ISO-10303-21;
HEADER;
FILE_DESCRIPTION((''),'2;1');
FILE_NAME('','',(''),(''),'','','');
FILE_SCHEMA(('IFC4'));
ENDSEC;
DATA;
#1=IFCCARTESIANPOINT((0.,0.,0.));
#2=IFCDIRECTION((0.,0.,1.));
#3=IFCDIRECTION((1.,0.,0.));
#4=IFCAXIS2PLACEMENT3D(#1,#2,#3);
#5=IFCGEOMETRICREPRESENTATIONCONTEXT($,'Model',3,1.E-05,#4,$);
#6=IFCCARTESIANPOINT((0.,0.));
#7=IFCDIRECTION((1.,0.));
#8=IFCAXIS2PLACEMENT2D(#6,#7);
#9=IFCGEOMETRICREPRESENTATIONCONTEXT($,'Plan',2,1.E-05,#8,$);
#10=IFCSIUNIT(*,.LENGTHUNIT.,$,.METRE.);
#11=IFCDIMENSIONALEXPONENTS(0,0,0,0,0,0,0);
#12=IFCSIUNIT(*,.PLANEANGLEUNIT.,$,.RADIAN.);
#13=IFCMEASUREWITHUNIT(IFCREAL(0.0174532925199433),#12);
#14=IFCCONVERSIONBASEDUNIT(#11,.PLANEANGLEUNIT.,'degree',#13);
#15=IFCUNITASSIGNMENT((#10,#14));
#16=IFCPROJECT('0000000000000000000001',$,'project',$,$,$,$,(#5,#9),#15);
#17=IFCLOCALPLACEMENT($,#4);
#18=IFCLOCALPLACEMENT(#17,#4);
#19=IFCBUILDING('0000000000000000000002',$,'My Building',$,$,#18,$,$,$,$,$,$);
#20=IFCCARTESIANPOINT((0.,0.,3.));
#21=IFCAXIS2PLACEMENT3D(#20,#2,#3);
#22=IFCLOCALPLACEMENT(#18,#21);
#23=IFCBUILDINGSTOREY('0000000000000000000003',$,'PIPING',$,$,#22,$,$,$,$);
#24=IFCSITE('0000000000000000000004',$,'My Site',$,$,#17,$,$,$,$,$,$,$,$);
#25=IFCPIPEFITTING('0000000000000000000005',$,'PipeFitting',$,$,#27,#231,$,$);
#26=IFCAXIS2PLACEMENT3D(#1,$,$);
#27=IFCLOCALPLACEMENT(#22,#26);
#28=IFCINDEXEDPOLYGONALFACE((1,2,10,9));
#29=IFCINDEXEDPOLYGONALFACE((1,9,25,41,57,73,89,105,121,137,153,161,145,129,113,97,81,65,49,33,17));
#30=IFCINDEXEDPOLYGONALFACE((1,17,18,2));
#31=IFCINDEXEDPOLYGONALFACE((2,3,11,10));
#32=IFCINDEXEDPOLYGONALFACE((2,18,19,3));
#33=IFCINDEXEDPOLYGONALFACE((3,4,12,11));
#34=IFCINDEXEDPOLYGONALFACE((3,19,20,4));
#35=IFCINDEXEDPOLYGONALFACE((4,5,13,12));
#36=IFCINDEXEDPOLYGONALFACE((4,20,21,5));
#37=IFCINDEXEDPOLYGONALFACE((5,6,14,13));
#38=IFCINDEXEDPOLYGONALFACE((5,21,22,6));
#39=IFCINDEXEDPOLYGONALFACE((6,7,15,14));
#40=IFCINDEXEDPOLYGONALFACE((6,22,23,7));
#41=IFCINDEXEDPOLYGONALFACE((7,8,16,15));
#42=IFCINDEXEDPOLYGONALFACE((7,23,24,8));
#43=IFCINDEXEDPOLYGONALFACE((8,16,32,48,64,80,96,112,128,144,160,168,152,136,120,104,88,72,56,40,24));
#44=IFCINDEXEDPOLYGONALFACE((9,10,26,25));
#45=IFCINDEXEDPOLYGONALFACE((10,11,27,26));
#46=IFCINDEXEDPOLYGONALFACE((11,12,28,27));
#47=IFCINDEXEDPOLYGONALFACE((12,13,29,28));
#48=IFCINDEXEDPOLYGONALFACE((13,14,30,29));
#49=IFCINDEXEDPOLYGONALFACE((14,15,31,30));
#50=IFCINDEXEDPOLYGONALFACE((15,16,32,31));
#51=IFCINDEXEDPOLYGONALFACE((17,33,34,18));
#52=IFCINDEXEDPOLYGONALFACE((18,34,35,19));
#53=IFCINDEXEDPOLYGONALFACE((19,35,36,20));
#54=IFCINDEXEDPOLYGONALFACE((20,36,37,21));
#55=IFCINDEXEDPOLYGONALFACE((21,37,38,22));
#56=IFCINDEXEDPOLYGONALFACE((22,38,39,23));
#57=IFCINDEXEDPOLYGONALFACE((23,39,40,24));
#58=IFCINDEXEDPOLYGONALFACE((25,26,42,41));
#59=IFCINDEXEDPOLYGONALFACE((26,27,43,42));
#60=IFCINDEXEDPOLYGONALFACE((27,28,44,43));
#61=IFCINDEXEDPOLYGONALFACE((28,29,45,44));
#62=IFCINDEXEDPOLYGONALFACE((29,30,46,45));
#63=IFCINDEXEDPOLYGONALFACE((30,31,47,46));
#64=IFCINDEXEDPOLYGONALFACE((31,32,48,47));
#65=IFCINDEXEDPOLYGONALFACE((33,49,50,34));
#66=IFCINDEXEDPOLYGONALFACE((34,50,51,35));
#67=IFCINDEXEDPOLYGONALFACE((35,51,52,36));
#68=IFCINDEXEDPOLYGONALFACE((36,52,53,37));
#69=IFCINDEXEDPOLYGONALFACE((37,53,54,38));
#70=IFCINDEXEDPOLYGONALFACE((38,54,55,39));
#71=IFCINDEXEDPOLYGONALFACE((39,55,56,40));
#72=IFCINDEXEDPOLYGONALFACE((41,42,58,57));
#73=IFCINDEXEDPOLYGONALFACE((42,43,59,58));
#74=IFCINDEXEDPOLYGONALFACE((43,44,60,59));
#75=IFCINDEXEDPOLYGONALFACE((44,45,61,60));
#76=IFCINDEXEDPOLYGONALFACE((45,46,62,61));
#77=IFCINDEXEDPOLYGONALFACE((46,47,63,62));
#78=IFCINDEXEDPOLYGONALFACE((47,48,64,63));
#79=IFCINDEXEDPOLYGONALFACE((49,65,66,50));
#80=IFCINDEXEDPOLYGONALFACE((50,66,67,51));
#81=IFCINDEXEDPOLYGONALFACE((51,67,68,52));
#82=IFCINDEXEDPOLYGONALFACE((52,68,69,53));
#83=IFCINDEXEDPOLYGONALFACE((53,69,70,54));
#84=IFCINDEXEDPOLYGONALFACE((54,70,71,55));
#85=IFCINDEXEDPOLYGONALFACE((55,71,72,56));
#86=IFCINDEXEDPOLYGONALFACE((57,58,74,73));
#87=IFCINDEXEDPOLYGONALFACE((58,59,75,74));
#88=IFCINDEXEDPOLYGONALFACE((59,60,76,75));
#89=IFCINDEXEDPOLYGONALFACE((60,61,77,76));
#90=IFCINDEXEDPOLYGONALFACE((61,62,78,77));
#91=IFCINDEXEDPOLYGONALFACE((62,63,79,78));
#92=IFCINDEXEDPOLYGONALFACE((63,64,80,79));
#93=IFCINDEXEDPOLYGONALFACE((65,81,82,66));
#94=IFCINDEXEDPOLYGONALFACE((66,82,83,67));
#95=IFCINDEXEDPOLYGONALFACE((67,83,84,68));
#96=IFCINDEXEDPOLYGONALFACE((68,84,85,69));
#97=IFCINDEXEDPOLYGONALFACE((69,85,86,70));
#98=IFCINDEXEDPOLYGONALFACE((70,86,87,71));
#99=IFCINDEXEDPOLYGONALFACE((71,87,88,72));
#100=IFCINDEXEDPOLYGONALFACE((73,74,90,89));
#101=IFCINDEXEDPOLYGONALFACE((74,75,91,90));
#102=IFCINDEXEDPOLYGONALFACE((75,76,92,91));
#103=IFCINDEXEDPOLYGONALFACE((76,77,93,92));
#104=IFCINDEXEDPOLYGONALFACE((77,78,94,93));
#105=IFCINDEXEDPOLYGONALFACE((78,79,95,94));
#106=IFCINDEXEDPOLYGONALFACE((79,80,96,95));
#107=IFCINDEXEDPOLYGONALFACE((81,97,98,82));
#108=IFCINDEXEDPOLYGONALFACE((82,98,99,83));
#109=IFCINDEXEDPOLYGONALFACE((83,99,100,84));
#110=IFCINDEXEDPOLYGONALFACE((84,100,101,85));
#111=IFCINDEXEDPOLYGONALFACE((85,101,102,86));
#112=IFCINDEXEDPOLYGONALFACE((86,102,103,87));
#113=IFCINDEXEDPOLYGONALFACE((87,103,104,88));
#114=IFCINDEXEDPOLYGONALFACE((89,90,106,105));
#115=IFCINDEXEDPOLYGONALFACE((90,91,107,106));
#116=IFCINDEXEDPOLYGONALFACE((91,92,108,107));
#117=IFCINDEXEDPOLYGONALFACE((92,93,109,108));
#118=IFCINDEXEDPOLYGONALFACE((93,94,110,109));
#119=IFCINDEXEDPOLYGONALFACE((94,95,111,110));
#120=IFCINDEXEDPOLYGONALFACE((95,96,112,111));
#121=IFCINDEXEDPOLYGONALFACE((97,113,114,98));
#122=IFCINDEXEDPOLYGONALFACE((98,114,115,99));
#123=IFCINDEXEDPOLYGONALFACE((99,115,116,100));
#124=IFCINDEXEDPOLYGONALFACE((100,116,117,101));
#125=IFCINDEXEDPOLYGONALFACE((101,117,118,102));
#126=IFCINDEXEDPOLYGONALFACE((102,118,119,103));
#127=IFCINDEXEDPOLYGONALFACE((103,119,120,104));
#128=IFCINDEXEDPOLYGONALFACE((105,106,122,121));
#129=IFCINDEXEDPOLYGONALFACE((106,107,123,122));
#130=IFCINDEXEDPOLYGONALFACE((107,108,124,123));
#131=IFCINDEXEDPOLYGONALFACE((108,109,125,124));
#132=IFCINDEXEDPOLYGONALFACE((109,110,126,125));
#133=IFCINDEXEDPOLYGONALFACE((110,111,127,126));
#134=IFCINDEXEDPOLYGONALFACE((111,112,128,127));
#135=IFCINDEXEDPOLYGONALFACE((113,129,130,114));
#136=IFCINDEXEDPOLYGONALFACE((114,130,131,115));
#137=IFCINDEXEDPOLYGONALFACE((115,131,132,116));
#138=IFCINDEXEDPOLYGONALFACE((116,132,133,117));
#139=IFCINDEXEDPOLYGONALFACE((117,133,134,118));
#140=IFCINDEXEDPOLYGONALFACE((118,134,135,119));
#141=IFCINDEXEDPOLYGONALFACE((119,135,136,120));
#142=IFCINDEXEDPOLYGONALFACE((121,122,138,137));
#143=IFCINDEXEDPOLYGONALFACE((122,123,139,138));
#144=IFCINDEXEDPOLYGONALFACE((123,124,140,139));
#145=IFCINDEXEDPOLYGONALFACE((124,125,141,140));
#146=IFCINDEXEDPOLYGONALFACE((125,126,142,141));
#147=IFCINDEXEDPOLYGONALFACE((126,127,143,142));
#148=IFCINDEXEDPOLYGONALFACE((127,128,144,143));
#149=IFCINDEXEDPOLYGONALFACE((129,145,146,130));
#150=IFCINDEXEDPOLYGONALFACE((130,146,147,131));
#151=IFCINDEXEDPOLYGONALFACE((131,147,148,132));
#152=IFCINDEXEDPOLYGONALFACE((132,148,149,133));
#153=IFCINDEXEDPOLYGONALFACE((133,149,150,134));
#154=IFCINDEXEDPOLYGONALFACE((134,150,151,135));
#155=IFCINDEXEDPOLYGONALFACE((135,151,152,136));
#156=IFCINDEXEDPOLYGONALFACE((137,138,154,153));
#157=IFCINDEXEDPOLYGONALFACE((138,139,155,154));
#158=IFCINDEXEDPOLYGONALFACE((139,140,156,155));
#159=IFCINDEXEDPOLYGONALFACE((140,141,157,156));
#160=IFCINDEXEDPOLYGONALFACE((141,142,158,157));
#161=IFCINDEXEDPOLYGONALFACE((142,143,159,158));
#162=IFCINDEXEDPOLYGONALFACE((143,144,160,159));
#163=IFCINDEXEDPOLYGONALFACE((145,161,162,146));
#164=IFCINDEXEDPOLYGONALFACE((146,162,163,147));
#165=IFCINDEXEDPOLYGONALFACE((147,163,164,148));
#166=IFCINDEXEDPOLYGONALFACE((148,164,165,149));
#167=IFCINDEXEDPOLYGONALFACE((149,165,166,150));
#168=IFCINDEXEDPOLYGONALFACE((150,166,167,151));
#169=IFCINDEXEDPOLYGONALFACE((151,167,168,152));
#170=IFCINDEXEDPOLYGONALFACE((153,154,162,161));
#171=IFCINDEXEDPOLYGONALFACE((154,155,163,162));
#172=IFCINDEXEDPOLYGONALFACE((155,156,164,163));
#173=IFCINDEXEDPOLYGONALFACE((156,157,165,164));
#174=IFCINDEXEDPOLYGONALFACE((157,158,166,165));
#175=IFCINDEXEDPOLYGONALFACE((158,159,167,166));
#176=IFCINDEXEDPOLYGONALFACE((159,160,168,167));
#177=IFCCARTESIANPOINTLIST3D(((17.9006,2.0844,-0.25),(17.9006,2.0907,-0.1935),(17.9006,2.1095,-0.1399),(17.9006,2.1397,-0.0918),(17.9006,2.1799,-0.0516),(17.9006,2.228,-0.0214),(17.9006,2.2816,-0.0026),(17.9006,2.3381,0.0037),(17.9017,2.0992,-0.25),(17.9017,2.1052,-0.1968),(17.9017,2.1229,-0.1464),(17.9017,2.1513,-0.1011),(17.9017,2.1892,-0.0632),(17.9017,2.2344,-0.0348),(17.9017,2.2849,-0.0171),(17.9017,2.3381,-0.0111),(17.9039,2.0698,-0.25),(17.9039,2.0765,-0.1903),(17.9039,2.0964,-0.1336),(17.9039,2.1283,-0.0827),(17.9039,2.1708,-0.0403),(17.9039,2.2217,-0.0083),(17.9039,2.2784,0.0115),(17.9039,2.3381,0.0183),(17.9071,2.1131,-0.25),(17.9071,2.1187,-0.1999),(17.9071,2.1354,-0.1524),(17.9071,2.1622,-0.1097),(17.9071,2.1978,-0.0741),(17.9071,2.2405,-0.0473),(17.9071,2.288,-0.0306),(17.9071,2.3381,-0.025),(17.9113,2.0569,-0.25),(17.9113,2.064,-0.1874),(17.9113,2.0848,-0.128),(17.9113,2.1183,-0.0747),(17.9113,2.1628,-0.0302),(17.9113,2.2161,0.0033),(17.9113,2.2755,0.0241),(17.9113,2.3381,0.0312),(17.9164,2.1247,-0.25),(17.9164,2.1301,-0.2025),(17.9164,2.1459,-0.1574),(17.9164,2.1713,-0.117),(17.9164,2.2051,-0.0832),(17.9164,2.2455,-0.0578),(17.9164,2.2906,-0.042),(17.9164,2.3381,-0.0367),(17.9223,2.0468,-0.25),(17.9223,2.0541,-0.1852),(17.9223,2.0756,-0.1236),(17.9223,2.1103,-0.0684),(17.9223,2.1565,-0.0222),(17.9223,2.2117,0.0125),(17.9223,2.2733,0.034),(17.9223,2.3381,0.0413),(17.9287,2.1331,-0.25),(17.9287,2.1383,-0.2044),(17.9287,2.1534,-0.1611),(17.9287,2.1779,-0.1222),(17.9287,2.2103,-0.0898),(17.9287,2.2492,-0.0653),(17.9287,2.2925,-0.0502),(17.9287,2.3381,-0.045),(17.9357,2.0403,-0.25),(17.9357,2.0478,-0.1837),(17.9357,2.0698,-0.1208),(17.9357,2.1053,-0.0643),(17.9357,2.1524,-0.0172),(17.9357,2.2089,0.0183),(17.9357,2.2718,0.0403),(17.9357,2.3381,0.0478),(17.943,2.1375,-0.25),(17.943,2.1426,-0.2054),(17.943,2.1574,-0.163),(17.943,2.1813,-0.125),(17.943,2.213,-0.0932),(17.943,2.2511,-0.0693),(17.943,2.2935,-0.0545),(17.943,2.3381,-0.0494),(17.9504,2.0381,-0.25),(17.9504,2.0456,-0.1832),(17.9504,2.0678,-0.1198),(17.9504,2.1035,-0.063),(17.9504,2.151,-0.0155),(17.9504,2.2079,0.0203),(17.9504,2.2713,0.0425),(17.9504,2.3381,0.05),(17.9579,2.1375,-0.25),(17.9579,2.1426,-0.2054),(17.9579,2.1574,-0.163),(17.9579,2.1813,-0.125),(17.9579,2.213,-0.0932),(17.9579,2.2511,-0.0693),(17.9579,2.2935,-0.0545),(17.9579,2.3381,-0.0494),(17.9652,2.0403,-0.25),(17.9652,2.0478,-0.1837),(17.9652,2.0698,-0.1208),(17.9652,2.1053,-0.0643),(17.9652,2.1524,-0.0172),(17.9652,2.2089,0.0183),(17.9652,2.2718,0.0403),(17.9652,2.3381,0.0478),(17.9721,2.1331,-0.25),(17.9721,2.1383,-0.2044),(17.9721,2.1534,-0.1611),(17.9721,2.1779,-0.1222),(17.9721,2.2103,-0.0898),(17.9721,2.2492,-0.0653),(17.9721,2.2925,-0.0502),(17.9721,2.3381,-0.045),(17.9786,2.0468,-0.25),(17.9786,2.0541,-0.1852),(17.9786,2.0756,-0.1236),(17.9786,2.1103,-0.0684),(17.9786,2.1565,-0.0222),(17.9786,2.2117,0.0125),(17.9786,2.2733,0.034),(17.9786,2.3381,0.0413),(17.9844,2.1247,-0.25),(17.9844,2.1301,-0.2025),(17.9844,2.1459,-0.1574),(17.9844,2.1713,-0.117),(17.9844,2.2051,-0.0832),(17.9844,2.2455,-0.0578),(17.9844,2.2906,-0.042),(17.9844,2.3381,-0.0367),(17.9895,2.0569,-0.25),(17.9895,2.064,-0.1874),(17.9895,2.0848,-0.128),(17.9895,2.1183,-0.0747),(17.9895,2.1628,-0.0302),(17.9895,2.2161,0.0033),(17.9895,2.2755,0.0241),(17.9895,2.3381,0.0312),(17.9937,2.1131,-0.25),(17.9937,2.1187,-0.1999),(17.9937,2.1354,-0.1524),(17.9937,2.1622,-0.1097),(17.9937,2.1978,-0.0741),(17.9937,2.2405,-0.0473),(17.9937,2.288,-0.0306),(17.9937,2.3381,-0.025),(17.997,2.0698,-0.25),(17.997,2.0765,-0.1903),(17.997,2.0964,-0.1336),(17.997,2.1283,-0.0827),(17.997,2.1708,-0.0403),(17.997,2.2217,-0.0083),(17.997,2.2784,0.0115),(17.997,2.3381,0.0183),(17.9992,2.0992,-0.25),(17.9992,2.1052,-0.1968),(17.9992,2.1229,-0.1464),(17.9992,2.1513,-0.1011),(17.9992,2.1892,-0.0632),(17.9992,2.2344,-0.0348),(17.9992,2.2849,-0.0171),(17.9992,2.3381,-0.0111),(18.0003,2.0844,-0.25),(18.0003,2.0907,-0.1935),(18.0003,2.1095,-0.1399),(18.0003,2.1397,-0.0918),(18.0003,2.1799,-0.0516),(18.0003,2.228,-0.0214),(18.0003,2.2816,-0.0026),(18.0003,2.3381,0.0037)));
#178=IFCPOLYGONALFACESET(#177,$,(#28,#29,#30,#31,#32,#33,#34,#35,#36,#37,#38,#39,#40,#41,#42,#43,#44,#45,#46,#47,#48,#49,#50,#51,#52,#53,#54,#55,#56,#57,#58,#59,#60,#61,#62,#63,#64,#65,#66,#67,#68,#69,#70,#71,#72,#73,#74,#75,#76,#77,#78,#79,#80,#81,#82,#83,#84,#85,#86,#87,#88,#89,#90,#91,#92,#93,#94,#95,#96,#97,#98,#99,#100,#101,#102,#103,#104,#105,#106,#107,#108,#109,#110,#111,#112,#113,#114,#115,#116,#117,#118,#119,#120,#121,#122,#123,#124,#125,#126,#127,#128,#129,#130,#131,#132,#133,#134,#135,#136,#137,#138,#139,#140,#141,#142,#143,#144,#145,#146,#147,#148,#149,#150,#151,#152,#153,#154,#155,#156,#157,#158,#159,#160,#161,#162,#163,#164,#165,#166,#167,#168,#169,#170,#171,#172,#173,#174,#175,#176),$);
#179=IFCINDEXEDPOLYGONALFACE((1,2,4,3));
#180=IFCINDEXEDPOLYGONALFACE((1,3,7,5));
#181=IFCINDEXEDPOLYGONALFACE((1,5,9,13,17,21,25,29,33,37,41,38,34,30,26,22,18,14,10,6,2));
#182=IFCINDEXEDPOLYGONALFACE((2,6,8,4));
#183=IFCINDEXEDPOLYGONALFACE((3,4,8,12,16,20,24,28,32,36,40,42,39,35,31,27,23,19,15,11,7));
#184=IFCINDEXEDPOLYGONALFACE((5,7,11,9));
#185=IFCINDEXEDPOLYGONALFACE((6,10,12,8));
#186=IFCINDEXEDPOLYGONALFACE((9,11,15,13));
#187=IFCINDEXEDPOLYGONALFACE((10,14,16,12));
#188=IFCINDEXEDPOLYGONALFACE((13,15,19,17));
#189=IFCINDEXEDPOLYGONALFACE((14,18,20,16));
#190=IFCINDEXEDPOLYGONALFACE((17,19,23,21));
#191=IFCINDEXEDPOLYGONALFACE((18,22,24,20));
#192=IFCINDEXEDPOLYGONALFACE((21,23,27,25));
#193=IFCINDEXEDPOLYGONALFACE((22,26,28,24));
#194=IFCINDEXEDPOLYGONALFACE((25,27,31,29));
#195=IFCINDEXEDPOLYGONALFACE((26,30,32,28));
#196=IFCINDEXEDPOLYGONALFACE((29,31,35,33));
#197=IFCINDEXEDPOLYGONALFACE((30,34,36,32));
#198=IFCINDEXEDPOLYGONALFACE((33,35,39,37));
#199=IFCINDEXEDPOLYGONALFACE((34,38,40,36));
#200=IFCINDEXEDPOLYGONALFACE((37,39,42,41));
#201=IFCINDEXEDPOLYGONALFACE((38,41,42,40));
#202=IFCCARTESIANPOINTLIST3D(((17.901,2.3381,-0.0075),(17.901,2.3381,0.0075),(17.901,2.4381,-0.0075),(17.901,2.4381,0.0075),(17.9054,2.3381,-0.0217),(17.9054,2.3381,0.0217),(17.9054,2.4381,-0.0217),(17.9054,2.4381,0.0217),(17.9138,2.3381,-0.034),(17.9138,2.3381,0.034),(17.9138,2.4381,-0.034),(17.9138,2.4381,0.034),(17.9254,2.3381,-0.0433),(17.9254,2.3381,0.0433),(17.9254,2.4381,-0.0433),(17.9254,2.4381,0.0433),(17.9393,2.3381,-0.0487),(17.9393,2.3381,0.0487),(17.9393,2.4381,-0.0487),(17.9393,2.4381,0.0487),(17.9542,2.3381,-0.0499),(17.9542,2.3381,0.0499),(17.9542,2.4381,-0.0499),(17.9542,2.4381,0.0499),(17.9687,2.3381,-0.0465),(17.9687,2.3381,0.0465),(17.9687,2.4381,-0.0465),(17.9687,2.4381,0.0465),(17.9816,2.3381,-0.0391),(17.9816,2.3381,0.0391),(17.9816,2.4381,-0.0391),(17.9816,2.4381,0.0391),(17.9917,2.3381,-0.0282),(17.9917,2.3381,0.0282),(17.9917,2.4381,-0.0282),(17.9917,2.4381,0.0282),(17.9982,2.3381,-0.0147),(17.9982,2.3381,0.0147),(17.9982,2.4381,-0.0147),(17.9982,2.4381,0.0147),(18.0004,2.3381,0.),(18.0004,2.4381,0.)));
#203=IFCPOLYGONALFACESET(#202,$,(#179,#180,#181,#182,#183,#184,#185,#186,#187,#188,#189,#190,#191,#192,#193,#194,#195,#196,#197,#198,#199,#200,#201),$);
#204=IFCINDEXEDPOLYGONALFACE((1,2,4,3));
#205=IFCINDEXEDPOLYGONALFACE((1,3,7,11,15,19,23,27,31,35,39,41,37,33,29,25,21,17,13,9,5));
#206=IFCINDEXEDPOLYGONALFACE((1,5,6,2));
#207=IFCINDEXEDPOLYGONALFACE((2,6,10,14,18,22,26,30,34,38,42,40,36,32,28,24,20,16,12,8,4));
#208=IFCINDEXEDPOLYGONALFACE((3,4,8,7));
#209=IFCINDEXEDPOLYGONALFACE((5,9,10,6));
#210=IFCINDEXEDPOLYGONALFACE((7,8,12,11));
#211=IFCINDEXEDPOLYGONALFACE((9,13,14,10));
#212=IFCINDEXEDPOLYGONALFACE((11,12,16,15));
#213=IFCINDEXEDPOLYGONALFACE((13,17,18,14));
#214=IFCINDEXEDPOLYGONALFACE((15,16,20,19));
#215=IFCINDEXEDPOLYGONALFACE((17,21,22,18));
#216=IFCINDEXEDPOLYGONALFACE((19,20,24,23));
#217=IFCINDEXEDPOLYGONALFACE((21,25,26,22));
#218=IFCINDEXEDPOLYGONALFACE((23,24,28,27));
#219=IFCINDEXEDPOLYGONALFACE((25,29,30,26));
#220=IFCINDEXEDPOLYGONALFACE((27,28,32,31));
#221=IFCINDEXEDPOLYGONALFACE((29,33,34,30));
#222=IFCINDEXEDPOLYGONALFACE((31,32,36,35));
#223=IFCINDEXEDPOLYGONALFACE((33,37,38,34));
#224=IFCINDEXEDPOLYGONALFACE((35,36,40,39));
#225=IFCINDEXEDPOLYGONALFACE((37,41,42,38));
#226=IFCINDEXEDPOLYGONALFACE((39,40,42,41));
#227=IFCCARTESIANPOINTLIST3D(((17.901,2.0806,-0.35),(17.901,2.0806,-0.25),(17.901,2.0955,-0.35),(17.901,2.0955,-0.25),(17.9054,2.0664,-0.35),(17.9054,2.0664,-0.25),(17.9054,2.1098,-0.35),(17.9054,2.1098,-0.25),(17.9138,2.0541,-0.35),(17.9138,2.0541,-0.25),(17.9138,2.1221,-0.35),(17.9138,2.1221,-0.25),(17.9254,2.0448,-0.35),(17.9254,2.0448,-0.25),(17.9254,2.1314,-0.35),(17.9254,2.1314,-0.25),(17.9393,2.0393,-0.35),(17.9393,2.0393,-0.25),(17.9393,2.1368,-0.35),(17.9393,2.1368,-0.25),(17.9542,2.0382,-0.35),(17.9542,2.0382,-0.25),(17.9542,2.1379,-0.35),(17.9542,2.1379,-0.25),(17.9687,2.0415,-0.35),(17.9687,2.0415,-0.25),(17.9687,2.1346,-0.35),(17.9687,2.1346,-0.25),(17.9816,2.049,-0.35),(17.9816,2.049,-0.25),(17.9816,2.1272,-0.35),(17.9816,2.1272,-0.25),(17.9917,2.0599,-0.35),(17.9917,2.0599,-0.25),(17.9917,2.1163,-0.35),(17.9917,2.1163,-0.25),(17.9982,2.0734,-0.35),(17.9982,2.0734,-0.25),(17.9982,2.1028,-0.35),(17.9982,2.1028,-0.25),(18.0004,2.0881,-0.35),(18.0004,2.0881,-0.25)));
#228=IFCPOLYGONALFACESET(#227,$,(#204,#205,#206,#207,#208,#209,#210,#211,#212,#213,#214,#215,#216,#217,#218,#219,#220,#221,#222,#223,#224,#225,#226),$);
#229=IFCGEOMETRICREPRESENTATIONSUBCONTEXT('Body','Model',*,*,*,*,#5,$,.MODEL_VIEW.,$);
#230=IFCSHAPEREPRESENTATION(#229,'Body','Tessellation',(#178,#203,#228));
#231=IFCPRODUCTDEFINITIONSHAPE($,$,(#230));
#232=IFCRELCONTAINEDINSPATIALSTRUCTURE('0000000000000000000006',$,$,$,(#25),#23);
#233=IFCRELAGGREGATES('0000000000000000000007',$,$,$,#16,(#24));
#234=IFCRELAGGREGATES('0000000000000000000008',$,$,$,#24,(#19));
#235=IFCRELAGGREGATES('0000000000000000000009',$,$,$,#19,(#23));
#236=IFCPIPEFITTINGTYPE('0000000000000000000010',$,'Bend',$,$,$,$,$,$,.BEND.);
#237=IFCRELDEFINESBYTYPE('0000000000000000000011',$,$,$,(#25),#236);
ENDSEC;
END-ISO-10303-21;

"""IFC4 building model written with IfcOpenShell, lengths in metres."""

from ifc_helpers import new_model, entity, si_unit, converted_unit, frame, origin_with_axes, origin_2d_with_axis, place, context, subcontext, project, spatial, circle, extrude, source, transform, mapped, type_object, type_shapes, element, save


model = new_model("IFC4")

# Units and contexts
model_context = context("Model", 3, precision=1e-05, world=origin_with_axes())
plan_context = context("Plan", 2, precision=1e-05, world=origin_2d_with_axis())
body_context = subcontext(model_context, "Body", "Model", "MODEL_VIEW")
ifc_project = project(units=[si_unit("LENGTHUNIT", "METRE"), converted_unit("PLANEANGLEUNIT", "degree", entity("IfcReal", 0.0174532925199433), si_unit("PLANEANGLEUNIT", "RADIAN"), dimensions=[0, 0, 0, 0, 0, 0, 0])], contexts=[model_context, plan_context])

# Site, building, storey
site_placement = place(None, origin_with_axes())
site = spatial("IfcSite", under=ifc_project, at=site_placement, Name="My Site")
building_placement = place(site_placement, origin_with_axes())
building = spatial("IfcBuilding", under=site, at=building_placement, Name="My Building")
storey_placement = place(building_placement, frame((0.0, 0.0, 3.0), z_axis=(0.0, 0.0, 1.0), x_axis=(1.0, 0.0, 0.0)))
storey = spatial("IfcBuildingStorey", under=building, at=storey_placement, Name="PIPING")

# Pipe fitting
pipe_fitting_type = type_object("IfcPipeFittingType", Name="Bend", PredefinedType="BEND")
shared_shape = source(origin_with_axes(), body_context, "Body", "SolidModel", [
    entity("IfcSweptDiskSolid", entity("IfcIndexedPolyCurve", entity("IfcCartesianPointList3D", [[0.0, 0.0, 0.1], [0.0, -0.0732, 0.2768], [0.0, -0.25, 0.35]]), [entity("IfcArcIndex", [1, 2, 3])]), 0.05),
    extrude(circle(Radius=0.05), origin_with_axes(), (0.0, 0.0, 1.0), 0.1),
    extrude(circle(Radius=0.05), frame((0.0, -0.25, 0.35), z_axis=(0.0, -1.0, 0.0), x_axis=(1.0, 0.0, 0.0)), (0.0, 0.0, 1.0), 0.1),
])
type_shapes(pipe_fitting_type, [shared_shape])
for number, where, z_axis, x_axis, name in (
    (1, (17.9504, 2.4381, 0.0), (0.0, -1.0, 0.0), (1.0, 0.0, 0.0), "PipeFitting"),
):
    element("IfcPipeFitting", number, at=place(storey_placement, frame(where, z_axis=z_axis, x_axis=x_axis)), inside=storey, type_object=pipe_fitting_type, Name=name, context=body_context, shape_type="MappedRepresentation", body=[
        mapped(shared_shape, transform((0.0, 0.0, 0.0), x_axis=(1.0, 0.0, 0.0), y_axis=(0.0, 1.0, 0.0), z_axis=(0.0, 0.0, 1.0), scale=1.0)),
    ])

save(model, "model.ifc")
